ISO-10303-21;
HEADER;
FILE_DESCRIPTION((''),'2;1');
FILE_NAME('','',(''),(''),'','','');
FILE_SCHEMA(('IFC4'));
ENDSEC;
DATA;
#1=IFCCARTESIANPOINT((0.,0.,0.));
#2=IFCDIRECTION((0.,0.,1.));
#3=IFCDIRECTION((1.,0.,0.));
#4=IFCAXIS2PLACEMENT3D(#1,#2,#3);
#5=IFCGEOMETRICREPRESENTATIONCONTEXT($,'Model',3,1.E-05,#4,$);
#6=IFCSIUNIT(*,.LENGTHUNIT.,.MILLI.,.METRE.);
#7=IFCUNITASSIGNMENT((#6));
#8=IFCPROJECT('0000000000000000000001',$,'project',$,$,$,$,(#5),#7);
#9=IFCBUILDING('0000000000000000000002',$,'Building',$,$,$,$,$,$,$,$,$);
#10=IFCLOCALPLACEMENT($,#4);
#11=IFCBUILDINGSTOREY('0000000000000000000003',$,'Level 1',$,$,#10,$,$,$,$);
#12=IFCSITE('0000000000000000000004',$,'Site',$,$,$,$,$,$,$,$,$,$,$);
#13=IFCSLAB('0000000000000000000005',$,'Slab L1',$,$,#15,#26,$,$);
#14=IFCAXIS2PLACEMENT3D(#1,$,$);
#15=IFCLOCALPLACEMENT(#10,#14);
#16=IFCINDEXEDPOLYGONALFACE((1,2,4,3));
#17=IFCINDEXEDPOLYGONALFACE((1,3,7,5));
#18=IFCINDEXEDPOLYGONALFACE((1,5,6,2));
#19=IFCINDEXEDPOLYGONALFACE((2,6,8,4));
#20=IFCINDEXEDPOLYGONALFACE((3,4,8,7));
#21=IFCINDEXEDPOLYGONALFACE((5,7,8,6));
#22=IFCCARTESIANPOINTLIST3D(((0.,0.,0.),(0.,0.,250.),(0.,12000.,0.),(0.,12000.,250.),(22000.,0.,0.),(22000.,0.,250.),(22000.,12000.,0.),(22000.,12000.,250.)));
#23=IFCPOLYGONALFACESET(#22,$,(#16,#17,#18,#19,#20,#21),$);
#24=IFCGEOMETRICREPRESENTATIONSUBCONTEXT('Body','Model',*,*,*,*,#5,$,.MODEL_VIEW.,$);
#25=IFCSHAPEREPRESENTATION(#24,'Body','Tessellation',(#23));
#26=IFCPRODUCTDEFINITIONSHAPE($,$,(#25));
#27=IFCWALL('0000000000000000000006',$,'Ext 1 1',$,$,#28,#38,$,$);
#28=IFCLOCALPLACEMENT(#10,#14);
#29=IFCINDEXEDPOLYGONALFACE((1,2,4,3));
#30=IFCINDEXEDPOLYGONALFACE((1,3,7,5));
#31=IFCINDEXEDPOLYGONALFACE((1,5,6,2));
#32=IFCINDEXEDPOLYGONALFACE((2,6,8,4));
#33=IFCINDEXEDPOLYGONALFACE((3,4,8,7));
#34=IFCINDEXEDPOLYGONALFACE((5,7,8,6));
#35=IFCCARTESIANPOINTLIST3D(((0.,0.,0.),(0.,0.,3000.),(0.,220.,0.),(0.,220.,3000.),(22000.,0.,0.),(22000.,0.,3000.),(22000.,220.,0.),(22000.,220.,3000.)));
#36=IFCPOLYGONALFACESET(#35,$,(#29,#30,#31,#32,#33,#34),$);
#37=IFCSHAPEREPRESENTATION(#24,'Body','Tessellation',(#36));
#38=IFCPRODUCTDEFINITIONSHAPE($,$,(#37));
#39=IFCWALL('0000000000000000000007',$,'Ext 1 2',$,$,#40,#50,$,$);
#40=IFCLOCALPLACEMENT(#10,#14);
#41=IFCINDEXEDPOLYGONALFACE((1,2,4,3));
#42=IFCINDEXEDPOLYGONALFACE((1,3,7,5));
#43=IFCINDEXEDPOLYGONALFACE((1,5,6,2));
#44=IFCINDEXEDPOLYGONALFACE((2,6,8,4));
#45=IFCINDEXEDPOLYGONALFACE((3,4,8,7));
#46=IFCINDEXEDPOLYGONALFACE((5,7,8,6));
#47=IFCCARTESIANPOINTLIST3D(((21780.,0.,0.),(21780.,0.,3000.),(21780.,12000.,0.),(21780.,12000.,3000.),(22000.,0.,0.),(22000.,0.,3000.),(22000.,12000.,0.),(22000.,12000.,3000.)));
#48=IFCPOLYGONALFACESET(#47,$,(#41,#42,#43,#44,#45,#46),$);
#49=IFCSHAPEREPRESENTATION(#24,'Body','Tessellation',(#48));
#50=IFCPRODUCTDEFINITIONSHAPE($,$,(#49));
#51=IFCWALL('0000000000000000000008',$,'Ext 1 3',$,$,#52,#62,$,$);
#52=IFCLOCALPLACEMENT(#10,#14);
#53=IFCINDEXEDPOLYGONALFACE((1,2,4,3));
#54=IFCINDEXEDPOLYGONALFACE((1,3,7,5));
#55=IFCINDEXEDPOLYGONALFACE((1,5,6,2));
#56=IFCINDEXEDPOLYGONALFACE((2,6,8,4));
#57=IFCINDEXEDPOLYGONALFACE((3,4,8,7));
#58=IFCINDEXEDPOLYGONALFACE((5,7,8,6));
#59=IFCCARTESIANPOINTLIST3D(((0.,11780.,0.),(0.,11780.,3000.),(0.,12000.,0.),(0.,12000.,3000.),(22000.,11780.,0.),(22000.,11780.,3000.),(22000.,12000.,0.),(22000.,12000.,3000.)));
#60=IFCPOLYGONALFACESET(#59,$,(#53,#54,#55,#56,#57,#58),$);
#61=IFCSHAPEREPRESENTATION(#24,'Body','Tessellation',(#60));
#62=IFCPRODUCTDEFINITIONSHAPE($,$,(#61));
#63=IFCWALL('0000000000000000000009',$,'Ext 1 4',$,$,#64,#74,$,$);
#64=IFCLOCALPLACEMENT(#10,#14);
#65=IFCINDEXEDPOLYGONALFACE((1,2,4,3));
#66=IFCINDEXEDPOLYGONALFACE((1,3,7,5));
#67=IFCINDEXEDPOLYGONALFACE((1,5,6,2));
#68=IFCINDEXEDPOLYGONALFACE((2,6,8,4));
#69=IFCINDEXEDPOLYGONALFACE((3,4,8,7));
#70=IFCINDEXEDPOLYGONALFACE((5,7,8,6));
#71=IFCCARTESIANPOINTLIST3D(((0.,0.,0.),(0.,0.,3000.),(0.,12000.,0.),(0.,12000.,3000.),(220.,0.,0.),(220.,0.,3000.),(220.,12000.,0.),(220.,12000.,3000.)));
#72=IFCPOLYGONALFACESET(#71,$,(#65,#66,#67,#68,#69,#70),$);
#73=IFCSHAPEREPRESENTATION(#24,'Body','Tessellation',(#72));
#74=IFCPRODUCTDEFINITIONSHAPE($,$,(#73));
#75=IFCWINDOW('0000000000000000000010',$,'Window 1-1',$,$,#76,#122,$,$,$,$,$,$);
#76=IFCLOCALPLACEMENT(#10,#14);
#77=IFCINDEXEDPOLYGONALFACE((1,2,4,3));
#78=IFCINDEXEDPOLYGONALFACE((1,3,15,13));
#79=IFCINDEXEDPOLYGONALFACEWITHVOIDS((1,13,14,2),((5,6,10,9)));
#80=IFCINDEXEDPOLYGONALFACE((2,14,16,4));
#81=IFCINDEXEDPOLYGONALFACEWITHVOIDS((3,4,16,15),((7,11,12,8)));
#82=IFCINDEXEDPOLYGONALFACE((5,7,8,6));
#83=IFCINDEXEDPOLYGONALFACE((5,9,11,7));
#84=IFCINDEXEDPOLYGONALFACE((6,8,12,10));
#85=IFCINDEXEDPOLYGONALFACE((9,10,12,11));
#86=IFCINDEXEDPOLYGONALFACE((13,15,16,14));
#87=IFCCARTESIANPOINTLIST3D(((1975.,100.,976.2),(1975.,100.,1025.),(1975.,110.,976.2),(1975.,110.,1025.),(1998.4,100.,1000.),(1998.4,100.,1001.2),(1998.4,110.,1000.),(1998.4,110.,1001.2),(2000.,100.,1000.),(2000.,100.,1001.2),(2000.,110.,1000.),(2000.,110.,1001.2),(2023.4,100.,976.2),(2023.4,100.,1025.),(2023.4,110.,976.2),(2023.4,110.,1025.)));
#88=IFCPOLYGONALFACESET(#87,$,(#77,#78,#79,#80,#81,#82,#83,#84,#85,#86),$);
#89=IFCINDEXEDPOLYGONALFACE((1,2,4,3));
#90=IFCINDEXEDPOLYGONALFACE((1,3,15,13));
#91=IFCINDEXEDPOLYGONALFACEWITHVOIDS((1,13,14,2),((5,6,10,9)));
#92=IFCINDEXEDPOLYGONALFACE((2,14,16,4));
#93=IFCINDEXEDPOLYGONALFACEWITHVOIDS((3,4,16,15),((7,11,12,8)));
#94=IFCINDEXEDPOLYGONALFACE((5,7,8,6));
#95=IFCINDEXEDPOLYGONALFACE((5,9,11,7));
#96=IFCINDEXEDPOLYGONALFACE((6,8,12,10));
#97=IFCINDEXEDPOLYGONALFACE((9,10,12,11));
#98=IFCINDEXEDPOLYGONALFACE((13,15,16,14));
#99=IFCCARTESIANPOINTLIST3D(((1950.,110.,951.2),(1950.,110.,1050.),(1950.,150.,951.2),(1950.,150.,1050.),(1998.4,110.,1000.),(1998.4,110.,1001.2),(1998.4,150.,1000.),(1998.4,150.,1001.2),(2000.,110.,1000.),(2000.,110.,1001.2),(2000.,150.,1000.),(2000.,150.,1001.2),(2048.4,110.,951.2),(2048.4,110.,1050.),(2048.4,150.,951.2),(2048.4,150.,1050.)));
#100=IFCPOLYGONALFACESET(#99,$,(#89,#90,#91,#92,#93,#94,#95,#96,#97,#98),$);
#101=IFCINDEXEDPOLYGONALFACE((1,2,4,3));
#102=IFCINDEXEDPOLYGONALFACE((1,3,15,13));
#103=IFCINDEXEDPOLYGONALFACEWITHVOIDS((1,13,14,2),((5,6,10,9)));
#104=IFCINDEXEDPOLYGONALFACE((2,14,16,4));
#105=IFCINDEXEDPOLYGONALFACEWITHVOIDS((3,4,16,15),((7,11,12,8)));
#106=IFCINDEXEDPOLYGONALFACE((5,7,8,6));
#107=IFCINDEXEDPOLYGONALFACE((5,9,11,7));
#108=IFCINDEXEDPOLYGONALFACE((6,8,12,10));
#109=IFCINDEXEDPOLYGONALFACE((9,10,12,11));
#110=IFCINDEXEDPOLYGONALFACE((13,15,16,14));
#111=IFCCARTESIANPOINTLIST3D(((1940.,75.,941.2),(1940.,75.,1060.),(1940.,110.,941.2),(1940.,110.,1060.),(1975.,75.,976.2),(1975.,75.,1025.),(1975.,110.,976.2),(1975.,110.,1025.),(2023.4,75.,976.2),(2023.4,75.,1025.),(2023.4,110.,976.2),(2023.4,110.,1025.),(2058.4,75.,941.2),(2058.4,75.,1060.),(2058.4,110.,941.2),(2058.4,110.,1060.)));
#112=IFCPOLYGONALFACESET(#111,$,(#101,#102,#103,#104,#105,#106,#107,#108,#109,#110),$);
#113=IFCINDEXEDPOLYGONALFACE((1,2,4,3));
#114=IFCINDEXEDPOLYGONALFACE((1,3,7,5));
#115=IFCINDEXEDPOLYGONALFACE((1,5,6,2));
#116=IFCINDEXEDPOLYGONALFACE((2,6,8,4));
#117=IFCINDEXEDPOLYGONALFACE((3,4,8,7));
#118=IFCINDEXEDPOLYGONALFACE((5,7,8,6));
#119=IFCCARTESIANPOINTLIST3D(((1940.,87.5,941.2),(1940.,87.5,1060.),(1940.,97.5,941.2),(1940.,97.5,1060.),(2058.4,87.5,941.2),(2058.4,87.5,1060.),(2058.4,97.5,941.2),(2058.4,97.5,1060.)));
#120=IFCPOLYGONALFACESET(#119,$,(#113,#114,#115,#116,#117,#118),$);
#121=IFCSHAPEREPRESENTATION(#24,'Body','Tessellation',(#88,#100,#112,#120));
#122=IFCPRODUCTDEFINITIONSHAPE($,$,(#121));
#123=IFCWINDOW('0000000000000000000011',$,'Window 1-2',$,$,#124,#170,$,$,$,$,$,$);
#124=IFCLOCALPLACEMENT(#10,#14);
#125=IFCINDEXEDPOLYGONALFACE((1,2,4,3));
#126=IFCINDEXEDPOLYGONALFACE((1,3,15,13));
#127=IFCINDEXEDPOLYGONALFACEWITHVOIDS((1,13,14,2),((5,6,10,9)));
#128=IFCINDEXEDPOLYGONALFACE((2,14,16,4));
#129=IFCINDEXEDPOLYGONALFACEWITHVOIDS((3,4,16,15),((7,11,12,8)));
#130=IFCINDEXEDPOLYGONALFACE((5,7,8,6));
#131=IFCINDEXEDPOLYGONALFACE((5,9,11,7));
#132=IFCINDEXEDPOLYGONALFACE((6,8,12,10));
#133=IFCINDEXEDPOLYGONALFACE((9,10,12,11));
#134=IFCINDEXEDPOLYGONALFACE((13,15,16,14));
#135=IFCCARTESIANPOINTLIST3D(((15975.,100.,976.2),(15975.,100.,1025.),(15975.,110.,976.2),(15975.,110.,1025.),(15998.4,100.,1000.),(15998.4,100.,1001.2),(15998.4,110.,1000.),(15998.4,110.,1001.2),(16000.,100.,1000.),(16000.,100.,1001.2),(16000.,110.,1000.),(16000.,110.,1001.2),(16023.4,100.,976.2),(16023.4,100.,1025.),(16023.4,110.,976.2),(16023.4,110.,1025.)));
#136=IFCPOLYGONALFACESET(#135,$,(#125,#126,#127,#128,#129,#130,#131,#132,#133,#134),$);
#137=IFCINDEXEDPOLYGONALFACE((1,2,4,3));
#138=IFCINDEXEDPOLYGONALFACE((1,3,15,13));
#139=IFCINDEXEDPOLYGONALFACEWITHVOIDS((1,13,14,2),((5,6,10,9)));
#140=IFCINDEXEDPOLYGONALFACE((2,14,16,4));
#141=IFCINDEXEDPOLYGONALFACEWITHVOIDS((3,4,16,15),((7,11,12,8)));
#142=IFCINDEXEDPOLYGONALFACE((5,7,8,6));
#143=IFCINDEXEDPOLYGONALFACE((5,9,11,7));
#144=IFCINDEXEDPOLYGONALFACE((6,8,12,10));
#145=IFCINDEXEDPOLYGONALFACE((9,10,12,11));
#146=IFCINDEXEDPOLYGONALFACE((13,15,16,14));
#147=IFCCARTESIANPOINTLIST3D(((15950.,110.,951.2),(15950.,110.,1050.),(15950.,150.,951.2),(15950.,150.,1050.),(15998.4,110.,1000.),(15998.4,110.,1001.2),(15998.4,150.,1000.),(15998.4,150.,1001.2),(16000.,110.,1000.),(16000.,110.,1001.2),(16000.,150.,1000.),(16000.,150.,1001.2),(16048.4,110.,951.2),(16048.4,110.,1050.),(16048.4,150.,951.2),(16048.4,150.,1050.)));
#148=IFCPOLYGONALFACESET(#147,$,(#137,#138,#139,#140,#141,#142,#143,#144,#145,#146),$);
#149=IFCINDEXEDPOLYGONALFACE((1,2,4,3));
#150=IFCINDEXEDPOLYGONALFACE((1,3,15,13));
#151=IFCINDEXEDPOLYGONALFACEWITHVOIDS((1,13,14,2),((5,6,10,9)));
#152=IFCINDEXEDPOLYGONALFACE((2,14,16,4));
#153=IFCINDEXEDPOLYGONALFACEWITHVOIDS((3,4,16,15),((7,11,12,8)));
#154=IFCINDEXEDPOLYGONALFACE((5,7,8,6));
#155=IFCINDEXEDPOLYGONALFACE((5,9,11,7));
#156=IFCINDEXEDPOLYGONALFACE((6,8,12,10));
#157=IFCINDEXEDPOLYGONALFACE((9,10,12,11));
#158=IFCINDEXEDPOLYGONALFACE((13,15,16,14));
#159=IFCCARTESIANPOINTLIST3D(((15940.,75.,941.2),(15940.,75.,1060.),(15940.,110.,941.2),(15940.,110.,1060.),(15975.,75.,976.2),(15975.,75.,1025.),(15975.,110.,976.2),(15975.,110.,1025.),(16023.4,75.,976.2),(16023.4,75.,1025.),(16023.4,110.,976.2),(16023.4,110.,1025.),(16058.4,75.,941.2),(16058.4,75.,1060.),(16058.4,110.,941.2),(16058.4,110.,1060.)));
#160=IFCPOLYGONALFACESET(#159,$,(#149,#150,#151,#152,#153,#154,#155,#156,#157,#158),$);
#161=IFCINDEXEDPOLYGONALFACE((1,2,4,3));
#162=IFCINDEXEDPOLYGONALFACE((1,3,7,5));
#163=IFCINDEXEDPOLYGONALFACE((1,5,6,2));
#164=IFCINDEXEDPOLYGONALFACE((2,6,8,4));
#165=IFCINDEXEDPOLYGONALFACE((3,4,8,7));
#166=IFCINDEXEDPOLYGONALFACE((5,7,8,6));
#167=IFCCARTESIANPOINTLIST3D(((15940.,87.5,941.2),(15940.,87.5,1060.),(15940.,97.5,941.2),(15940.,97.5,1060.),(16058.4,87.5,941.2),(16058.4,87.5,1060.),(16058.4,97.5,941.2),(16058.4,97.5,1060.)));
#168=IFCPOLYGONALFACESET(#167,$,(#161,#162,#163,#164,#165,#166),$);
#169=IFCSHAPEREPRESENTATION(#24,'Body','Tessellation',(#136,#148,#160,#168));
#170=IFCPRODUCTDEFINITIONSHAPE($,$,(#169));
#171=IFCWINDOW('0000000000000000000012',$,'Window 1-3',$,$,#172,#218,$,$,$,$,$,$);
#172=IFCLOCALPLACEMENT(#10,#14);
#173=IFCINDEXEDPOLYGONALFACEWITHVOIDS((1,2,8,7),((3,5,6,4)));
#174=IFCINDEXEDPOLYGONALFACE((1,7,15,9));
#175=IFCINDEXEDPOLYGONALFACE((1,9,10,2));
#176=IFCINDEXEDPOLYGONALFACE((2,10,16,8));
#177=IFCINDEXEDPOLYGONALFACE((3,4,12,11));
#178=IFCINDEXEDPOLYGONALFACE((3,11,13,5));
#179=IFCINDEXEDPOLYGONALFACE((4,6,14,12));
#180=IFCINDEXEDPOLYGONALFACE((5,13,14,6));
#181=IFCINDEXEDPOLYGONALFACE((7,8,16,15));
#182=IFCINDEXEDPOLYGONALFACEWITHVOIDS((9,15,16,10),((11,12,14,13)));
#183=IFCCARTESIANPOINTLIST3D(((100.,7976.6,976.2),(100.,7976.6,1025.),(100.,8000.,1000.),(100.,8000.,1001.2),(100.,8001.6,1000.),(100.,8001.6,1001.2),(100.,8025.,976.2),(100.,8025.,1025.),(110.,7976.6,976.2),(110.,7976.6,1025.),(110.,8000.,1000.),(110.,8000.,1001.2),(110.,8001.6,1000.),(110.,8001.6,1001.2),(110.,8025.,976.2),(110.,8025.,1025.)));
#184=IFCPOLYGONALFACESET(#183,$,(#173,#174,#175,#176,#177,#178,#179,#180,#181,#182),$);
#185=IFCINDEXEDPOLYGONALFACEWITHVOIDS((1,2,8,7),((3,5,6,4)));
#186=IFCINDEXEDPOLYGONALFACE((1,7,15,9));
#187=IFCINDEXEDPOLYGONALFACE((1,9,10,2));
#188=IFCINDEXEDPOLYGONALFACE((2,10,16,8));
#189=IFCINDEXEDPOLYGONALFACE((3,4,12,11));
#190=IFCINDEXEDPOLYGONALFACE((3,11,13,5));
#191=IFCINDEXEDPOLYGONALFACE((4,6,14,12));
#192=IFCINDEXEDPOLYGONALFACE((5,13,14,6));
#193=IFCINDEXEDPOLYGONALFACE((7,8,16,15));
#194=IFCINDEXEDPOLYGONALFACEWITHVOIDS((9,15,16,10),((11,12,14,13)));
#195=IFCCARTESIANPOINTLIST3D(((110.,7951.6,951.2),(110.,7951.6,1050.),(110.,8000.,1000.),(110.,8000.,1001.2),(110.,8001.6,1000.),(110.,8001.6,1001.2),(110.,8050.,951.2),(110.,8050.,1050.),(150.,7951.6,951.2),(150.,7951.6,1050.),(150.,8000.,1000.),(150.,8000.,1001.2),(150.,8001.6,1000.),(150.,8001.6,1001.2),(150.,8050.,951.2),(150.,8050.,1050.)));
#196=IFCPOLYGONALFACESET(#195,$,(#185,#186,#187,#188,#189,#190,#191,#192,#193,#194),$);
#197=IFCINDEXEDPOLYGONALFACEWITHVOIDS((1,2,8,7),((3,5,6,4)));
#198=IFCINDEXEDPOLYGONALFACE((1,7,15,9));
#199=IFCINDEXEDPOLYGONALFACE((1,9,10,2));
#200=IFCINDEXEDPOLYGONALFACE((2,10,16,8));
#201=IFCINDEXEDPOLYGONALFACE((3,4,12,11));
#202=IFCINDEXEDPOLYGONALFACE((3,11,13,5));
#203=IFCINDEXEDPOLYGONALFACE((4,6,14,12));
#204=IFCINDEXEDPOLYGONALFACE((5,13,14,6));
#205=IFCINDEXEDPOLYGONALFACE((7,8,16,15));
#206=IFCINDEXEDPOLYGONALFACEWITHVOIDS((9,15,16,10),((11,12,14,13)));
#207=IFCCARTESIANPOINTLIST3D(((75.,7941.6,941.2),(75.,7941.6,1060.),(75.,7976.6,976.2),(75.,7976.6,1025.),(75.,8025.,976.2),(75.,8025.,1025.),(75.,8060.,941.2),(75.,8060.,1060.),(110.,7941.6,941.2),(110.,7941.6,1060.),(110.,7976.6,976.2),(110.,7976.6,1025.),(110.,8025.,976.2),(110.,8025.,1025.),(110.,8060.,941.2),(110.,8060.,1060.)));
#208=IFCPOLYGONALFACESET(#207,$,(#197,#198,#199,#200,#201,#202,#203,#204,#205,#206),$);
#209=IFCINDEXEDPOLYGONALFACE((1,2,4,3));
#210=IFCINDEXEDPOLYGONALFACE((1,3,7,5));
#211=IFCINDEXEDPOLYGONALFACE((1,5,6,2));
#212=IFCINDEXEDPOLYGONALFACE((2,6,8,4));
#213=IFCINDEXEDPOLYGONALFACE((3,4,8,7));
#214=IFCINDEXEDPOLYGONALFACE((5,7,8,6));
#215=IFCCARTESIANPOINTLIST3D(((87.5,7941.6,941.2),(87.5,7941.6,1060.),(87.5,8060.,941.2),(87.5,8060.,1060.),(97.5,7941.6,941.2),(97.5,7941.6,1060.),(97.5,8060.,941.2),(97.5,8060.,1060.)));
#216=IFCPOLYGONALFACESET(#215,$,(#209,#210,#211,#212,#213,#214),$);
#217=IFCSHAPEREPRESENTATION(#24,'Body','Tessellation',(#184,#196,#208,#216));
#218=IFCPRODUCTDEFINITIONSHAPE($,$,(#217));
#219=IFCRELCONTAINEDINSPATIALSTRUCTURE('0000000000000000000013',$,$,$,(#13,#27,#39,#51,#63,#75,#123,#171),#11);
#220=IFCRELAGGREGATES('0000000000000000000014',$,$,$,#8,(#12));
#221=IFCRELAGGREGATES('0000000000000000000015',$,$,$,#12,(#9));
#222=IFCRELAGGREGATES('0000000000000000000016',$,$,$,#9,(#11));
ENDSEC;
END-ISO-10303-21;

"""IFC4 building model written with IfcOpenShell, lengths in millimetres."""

from ifc_helpers import new_model, si_unit, frame, origin_with_axes, place, context, subcontext, project, spatial, line, indexed_curve, outline, extrude, element, save


model = new_model("IFC4")

# Units and contexts
model_context = context("Model", 3, precision=1e-05, world=origin_with_axes())
body_context = subcontext(model_context, "Body", "Model", "MODEL_VIEW")
ifc_project = project(units=[si_unit("LENGTHUNIT", "METRE", prefix="MILLI")], contexts=[model_context])

# Site, building, storey
site = spatial("IfcSite", under=ifc_project, Name="Site")
building = spatial("IfcBuilding", under=site, Name="Building")
storey_placement = place(None, origin_with_axes())
storey = spatial("IfcBuildingStorey", under=building, at=storey_placement, Name="Level 1")

# Slab
slab_placement = place(storey_placement, origin_with_axes())
element("IfcSlab", 1, at=slab_placement, inside=storey, Name="Slab L1", context=body_context, shape_type="SweptSolid", body=[
    extrude(outline(indexed_curve([(0.0, 0.0), (22000.0, 0.0), (22000.0, 12000.0), (0.0, 12000.0), (0.0, 0.0)])), None, (0.0, 0.0, 1.0), 250.0),
])

# Walls
wall_1_placement = place(storey_placement, origin_with_axes())
element("IfcWall", 2, at=wall_1_placement, inside=storey, Name="Ext 1 1", context=body_context, shape_type="SweptSolid", body=[
    extrude(outline(indexed_curve([(0.0, 0.0), (0.0, 220.0), (22000.0, 220.0), (22000.0, 0.0), (0.0, 0.0)], self_intersect=False)), origin_with_axes(), (0.0, 0.0, 1.0), 3000.0),
])
wall_2_placement = place(storey_placement, frame((22000.0, 0.0, 0.0), z_axis=(0.0, 0.0, 1.0), x_axis=(0.0, 1.0, 0.0)))
element("IfcWall", 3, at=wall_2_placement, inside=storey, Name="Ext 1 2", context=body_context, shape_type="SweptSolid", body=[
    extrude(outline(indexed_curve([(0.0, 0.0), (0.0, 220.0), (12000.0, 220.0), (12000.0, 0.0), (0.0, 0.0)], self_intersect=False)), origin_with_axes(), (0.0, 0.0, 1.0), 3000.0),
])
wall_3_placement = place(storey_placement, frame((22000.0, 12000.0, 0.0), z_axis=(0.0, 0.0, 1.0), x_axis=(-1.0, 0.0, 0.0)))
element("IfcWall", 4, at=wall_3_placement, inside=storey, Name="Ext 1 3", context=body_context, shape_type="SweptSolid", body=[
    extrude(outline(indexed_curve([(0.0, 0.0), (0.0, 220.0), (22000.0, 220.0), (22000.0, 0.0), (0.0, 0.0)], self_intersect=False)), origin_with_axes(), (0.0, 0.0, 1.0), 3000.0),
])
wall_4_placement = place(storey_placement, frame((0.0, 12000.0, 0.0), z_axis=(0.0, 0.0, 1.0), x_axis=(0.0, -1.0, 0.0)))
element("IfcWall", 5, at=wall_4_placement, inside=storey, Name="Ext 1 4", context=body_context, shape_type="SweptSolid", body=[
    extrude(outline(indexed_curve([(0.0, 0.0), (0.0, 220.0), (12000.0, 220.0), (12000.0, 0.0), (0.0, 0.0)], self_intersect=False)), origin_with_axes(), (0.0, 0.0, 1.0), 3000.0),
])

# Windows
for number, where, z_axis, x_axis, name in (
    (6, (2000.0, 200.0, 1000.0), (0.0, 0.0, 1.0), (-1.0, 0.0, 0.0), "Window 1-1"),
    (7, (16000.0, 200.0, 1000.0), (0.0, 0.0, 1.0), (-1.0, 0.0, 0.0), "Window 1-2"),
    (8, (200.0, 8000.0, 1000.0), (0.0, 0.0, 1.0), (0.0, 1.0, 0.0), "Window 1-3"),
):
    element("IfcWindow", number, at=place(storey_placement, frame(where, z_axis=z_axis, x_axis=x_axis)), inside=storey, Name=name, context=body_context, shape_type="SweptSolid", body=[
        extrude(outline(indexed_curve([(0.0, 0.0), (1.6, 0.0), (1.6, 1.2), (0.0, 1.2)], segments=[line(1, 2, 3, 4, 1)]), holes=[indexed_curve([(25.0, 25.0), (-23.4, 25.0), (-23.4, -23.8), (25.0, -23.8)], segments=[line(1, 2, 3, 4, 1)])]), frame((0.0, 90.0, 0.0), z_axis=(0.0, -1.0, 0.0), x_axis=(1.0, 0.0, 0.0)), (0.0, 0.0, -1.0), 10.0),
        extrude(outline(indexed_curve([(0.0, 0.0), (1.6, 0.0), (1.6, 1.2), (0.0, 1.2)], segments=[line(1, 2, 3, 4, 1)]), holes=[indexed_curve([(50.0, 50.0), (-48.4, 50.0), (-48.4, -48.8), (50.0, -48.8)], segments=[line(1, 2, 3, 4, 1)])]), frame((0.0, 50.0, 0.0), z_axis=(0.0, -1.0, 0.0), x_axis=(1.0, 0.0, 0.0)), (0.0, 0.0, -1.0), 40.0),
        extrude(outline(indexed_curve([(0.0, 0.0), (-48.4, 0.0), (-48.4, -48.8), (0.0, -48.8)], segments=[line(1, 2, 3, 4, 1)]), holes=[indexed_curve([(35.0, 35.0), (-83.4, 35.0), (-83.4, -83.8), (35.0, -83.8)], segments=[line(1, 2, 3, 4, 1)])]), frame((25.0, 90.0, 25.0), z_axis=(0.0, -1.0, 0.0), x_axis=(1.0, 0.0, 0.0)), (0.0, 0.0, -1.0), 35.0),
        extrude(outline(indexed_curve([(35.0, 35.0), (-83.4, 35.0), (-83.4, -83.8), (35.0, -83.8)], segments=[line(1, 2, 3, 4, 1)])), frame((25.0, 102.5, 25.0), z_axis=(0.0, -1.0, 0.0), x_axis=(1.0, 0.0, 0.0)), (0.0, 0.0, -1.0), 10.0),
    ])

save(model, "model.ifc")
